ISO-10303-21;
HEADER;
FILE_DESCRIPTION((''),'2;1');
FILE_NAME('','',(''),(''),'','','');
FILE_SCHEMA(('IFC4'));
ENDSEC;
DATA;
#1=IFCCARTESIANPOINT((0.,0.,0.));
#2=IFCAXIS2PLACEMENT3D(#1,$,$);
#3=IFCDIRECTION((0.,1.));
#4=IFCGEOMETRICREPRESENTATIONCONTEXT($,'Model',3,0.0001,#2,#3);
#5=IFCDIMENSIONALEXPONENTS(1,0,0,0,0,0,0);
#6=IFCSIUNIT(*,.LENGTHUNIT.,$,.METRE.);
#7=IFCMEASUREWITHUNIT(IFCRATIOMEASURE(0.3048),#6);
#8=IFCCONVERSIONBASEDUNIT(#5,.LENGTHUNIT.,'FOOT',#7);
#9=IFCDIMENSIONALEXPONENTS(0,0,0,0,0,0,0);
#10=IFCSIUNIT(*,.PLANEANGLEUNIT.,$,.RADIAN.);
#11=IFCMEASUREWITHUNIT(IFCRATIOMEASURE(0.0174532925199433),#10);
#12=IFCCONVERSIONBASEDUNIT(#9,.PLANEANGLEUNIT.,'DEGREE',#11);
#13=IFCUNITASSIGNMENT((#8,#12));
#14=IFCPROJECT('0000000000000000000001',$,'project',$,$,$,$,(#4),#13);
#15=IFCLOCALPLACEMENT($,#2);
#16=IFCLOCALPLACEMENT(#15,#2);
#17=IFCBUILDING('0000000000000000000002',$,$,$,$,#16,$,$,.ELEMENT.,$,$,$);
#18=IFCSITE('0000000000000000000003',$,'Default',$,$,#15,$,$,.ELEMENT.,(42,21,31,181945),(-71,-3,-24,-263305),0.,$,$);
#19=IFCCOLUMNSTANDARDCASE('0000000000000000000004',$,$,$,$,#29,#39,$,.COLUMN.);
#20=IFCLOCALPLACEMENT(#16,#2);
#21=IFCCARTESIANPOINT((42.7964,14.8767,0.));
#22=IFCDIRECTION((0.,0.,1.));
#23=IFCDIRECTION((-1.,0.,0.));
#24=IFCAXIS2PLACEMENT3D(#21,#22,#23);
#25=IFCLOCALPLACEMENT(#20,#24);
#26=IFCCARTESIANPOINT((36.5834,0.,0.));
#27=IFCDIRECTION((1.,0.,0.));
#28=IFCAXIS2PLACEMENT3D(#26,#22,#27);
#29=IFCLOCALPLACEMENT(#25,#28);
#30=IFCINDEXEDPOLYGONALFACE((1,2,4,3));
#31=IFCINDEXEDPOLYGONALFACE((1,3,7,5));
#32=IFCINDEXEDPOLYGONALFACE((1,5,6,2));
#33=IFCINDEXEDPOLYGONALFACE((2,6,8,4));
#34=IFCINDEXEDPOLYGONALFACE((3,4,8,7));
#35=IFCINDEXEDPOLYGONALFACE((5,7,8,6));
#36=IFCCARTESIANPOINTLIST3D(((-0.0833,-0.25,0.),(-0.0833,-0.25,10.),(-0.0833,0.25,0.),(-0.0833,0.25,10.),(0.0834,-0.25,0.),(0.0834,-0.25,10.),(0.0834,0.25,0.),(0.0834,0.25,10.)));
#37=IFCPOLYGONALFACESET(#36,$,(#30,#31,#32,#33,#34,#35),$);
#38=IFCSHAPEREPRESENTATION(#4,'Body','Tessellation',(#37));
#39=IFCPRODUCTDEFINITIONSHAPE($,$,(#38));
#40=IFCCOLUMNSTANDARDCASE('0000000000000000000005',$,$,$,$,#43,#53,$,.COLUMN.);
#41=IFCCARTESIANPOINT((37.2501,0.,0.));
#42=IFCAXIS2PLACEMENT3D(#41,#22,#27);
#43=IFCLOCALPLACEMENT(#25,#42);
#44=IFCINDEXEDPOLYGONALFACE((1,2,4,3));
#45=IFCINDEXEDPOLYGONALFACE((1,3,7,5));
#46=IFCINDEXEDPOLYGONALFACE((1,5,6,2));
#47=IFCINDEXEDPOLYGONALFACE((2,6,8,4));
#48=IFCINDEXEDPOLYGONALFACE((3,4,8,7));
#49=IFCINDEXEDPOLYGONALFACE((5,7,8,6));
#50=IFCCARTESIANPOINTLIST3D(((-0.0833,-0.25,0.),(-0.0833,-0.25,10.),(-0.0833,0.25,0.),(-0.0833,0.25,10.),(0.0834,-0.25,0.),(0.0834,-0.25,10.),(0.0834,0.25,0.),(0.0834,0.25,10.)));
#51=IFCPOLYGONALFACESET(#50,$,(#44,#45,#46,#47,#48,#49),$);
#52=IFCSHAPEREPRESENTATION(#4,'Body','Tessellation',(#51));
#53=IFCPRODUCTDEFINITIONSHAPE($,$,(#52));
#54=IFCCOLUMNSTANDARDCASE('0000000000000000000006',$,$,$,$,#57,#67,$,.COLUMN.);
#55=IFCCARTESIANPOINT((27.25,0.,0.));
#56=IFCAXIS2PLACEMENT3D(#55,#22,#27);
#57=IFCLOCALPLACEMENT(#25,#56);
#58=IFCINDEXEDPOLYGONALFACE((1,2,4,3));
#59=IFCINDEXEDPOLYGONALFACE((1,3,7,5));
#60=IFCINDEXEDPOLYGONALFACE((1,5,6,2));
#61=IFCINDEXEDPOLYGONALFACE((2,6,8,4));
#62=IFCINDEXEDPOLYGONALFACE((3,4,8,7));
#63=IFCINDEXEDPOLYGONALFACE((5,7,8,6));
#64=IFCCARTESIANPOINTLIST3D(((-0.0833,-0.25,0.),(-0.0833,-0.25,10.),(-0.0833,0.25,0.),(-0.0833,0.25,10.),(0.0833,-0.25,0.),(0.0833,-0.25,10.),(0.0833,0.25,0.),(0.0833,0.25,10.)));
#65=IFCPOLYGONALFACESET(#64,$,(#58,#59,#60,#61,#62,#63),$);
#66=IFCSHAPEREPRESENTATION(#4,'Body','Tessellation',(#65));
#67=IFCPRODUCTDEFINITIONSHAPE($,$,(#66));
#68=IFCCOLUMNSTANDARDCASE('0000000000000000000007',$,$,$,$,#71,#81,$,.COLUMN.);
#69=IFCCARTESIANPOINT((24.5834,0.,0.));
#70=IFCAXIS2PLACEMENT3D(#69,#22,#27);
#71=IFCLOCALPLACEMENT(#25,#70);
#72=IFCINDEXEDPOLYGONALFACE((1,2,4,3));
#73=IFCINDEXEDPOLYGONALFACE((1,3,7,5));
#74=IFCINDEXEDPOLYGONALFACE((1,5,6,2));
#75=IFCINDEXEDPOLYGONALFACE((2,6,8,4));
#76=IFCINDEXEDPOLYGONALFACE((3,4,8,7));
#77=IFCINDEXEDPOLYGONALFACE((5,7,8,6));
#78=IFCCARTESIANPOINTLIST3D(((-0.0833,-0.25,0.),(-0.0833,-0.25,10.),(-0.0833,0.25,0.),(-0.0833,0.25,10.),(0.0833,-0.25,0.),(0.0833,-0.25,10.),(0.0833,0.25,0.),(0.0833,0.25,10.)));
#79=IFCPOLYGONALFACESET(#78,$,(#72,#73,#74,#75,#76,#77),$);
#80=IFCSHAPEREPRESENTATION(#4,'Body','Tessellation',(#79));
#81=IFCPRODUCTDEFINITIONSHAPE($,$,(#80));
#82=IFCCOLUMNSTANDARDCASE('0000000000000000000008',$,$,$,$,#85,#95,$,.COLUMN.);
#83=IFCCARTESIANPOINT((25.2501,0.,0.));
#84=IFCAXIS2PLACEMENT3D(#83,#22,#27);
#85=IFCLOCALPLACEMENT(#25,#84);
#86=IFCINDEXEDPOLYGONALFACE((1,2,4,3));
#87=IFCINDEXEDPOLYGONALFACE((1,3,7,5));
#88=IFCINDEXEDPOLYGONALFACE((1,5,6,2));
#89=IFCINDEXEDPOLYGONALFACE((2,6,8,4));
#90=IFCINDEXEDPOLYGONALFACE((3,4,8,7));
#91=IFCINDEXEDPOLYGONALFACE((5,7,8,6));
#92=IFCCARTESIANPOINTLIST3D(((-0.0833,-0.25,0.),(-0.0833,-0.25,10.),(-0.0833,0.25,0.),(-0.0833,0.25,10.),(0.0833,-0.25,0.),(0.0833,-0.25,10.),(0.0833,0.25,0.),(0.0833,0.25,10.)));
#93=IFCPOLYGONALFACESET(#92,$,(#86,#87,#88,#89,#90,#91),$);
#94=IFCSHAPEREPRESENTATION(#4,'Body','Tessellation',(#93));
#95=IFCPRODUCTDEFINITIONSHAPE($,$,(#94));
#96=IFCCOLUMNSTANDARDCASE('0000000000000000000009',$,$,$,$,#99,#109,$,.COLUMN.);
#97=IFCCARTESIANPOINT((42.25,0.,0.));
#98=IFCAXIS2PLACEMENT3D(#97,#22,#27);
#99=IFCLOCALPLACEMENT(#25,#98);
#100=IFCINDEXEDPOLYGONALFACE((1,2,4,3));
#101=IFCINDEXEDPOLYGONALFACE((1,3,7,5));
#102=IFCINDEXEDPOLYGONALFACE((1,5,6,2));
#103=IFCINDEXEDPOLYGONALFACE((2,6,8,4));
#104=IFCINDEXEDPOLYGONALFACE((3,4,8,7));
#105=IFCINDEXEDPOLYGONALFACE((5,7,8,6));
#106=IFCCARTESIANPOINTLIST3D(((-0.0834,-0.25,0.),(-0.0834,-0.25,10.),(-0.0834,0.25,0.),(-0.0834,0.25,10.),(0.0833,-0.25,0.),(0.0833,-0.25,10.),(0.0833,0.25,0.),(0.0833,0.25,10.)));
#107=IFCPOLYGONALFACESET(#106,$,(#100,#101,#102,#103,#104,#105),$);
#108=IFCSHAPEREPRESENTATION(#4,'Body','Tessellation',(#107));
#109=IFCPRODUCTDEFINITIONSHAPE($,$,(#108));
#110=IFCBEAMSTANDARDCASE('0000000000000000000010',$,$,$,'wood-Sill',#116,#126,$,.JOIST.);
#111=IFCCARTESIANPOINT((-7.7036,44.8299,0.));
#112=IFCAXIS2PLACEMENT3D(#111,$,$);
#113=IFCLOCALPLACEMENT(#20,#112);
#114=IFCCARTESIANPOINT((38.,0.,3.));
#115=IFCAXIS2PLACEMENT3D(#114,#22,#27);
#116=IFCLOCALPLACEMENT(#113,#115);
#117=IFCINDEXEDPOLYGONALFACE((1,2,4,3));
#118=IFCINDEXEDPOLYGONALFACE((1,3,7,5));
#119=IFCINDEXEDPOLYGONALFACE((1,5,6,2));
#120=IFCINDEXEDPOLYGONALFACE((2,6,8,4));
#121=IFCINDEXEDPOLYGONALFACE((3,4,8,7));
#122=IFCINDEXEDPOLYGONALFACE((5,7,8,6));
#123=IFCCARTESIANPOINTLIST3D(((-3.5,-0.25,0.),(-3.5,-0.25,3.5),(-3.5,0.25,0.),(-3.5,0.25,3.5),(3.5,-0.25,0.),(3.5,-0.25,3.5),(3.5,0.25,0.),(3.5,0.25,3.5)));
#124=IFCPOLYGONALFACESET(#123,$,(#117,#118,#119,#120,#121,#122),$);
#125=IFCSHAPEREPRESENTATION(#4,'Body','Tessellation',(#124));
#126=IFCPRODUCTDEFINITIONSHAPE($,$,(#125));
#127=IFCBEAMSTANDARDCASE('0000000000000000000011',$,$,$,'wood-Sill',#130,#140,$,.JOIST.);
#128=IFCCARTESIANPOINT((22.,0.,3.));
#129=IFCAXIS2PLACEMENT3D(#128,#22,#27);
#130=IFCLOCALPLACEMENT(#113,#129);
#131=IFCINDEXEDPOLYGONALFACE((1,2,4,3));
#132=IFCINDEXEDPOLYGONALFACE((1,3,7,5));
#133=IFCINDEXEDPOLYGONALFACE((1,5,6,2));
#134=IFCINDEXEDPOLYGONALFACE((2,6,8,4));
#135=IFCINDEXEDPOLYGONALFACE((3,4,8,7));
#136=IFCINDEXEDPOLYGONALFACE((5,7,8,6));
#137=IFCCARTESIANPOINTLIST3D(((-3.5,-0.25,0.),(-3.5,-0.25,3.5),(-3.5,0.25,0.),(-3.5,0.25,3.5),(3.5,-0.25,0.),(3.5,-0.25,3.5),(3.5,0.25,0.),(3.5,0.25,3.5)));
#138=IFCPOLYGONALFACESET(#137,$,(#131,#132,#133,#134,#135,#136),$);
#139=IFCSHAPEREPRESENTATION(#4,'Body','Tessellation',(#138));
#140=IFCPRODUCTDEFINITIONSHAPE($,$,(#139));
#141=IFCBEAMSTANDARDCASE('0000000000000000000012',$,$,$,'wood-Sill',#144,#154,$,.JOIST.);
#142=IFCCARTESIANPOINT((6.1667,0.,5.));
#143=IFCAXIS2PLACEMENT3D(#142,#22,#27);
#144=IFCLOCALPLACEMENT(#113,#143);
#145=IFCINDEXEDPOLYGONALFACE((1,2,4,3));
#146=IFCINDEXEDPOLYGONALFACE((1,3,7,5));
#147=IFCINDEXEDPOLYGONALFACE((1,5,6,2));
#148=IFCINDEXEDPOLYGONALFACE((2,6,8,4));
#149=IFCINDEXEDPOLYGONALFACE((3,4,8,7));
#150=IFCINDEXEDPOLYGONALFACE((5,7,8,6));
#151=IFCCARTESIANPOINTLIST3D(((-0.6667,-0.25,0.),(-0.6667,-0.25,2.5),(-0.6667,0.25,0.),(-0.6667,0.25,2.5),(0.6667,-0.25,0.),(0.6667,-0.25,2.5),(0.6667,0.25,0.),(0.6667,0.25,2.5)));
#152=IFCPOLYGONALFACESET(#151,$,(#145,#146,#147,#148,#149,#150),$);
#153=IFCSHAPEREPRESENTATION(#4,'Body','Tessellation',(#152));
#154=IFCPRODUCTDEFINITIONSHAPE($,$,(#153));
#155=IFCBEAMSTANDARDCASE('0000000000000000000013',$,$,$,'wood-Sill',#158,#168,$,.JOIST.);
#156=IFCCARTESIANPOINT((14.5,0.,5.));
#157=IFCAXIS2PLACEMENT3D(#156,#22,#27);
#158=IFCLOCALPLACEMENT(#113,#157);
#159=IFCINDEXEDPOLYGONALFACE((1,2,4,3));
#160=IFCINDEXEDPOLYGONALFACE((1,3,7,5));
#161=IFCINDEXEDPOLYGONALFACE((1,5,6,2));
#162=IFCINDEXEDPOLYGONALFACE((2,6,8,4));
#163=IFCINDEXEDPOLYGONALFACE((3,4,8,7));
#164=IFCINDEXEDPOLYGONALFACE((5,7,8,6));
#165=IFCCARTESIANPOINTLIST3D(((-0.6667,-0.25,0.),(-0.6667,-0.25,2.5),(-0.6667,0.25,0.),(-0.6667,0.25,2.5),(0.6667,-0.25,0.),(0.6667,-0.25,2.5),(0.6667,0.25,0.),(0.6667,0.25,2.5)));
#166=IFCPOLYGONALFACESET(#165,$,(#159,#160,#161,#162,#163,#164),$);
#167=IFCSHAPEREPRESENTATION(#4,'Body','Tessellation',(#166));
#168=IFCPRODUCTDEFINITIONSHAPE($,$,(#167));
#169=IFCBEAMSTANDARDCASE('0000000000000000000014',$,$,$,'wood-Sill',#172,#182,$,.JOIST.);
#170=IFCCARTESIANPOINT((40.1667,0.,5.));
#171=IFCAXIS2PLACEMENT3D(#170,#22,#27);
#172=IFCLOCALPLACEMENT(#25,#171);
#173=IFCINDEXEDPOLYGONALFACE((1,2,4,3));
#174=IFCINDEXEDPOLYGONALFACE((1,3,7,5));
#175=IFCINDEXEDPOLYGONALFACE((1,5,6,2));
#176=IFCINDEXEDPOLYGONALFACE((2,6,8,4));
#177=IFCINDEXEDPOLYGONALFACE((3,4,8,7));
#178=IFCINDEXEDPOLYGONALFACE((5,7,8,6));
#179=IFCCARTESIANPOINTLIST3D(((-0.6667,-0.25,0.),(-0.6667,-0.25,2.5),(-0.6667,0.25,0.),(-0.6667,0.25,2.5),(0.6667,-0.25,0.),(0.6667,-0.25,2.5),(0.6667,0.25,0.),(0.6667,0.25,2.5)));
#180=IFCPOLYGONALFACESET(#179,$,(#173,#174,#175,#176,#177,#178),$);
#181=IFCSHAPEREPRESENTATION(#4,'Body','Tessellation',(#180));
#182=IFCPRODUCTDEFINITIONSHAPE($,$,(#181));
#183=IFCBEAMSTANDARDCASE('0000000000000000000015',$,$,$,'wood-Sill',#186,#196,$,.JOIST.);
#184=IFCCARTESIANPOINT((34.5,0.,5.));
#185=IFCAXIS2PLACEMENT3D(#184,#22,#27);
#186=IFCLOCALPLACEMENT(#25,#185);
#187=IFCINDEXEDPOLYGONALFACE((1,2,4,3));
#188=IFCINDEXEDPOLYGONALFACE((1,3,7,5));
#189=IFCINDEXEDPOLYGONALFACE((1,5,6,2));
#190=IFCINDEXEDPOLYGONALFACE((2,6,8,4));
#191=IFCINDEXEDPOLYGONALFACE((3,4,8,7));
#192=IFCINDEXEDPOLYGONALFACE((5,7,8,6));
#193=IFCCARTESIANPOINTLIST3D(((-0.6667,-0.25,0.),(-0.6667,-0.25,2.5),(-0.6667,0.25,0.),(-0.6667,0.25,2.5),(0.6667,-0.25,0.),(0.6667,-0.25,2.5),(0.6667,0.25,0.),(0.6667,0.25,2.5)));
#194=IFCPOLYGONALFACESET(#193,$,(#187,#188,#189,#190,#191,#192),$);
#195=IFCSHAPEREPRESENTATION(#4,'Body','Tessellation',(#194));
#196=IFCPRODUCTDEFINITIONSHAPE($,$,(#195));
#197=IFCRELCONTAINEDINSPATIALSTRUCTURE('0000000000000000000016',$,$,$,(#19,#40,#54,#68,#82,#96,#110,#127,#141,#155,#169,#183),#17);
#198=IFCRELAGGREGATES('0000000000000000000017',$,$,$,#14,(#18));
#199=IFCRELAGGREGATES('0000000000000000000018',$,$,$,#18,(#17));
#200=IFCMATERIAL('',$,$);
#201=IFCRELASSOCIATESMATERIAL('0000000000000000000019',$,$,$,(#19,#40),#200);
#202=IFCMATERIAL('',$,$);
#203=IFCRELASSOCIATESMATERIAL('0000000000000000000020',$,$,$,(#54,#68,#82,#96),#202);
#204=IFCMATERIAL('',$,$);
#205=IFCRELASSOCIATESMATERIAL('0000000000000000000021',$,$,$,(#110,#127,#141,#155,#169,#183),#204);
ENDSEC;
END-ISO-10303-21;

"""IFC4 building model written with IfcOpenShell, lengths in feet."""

from ifc_helpers import new_model, entity, si_unit, converted_unit, direction, frame, origin, place, context, project, spatial, rectangle, extrude, material, element, save


model = new_model("IFC4")

# Units and contexts
model_context = context("Model", 3, precision=0.0001, world=origin(), true_north=direction((0.0, 1.0)))
ifc_project = project(units=[converted_unit("LENGTHUNIT", "FOOT", entity("IfcRatioMeasure", 0.3048), si_unit("LENGTHUNIT", "METRE"), dimensions=[1, 0, 0, 0, 0, 0, 0]), converted_unit("PLANEANGLEUNIT", "DEGREE", entity("IfcRatioMeasure", 0.0174532925199433), si_unit("PLANEANGLEUNIT", "RADIAN"), dimensions=[0, 0, 0, 0, 0, 0, 0])], contexts=[model_context])

# Site, building
site_placement = place(None, origin())
site = spatial("IfcSite", under=ifc_project, at=site_placement, Name="Default", CompositionType="ELEMENT", RefLatitude=(42, 21, 31, 181945), RefLongitude=(-71, -3, -24, -263305), RefElevation=0.0)
building_placement = place(site_placement, origin())
building = spatial("IfcBuilding", under=site, at=building_placement, CompositionType="ELEMENT")

# Columns
placement_1 = place(building_placement, origin())
placement_2 = place(placement_1, frame((-7.7036, 44.8299, 0.0)))
ifc_material_1 = material(Name="")
ifc_material_2 = material(Name="")
placement_3 = place(placement_1, frame((42.7964, 14.8767, 0.0), z_axis=(0.0, 0.0, 1.0), x_axis=(-1.0, 0.0, 0.0)))
for number, where, z_axis, x_axis in (
    (1, (36.5834, 0.0, 0.0), (0.0, 0.0, 1.0), (1.0, 0.0, 0.0)),
    (2, (37.2501, 0.0, 0.0), (0.0, 0.0, 1.0), (1.0, 0.0, 0.0)),
):
    element("IfcColumnStandardCase", number, at=place(placement_3, frame(where, z_axis=z_axis, x_axis=x_axis)), inside=building, material=ifc_material_1, PredefinedType="COLUMN", context=model_context, shape_type="SweptSolid", body=[
        extrude(rectangle(XDim=0.1667, YDim=0.5), origin(), (0.0, 0.0, 1.0), 10.0),
    ])
for number, where, z_axis, x_axis in (
    (3, (27.25, 0.0, 0.0), (0.0, 0.0, 1.0), (1.0, 0.0, 0.0)),
    (4, (24.5834, 0.0, 0.0), (0.0, 0.0, 1.0), (1.0, 0.0, 0.0)),
    (5, (25.2501, 0.0, 0.0), (0.0, 0.0, 1.0), (1.0, 0.0, 0.0)),
    (6, (42.25, 0.0, 0.0), (0.0, 0.0, 1.0), (1.0, 0.0, 0.0)),
):
    element("IfcColumnStandardCase", number, at=place(placement_3, frame(where, z_axis=z_axis, x_axis=x_axis)), inside=building, material=ifc_material_2, PredefinedType="COLUMN", context=model_context, shape_type="SweptSolid", body=[
        extrude(rectangle(XDim=0.1667, YDim=0.5), origin(), (0.0, 0.0, 1.0), 10.0),
    ])

# Beams
ifc_material_3 = material(Name="")
for number, where, z_axis, x_axis in (
    (7, (38.0, 0.0, 3.0), (0.0, 0.0, 1.0), (1.0, 0.0, 0.0)),
    (8, (22.0, 0.0, 3.0), (0.0, 0.0, 1.0), (1.0, 0.0, 0.0)),
):
    element("IfcBeamStandardCase", number, at=place(placement_2, frame(where, z_axis=z_axis, x_axis=x_axis)), inside=building, material=ifc_material_3, ObjectType="wood-Sill", PredefinedType="JOIST", context=model_context, shape_type="SweptSolid", body=[
        extrude(rectangle(XDim=7.0, YDim=0.5), origin(), (0.0, 0.0, 1.0), 3.5),
    ])
for number, where, z_axis, x_axis in (
    (9, (6.1667, 0.0, 5.0), (0.0, 0.0, 1.0), (1.0, 0.0, 0.0)),
    (10, (14.5, 0.0, 5.0), (0.0, 0.0, 1.0), (1.0, 0.0, 0.0)),
):
    element("IfcBeamStandardCase", number, at=place(placement_2, frame(where, z_axis=z_axis, x_axis=x_axis)), inside=building, material=ifc_material_3, ObjectType="wood-Sill", PredefinedType="JOIST", context=model_context, shape_type="SweptSolid", body=[
        extrude(rectangle(XDim=1.3333, YDim=0.5), origin(), (0.0, 0.0, 1.0), 2.5),
    ])
for number, where, z_axis, x_axis in (
    (11, (40.1667, 0.0, 5.0), (0.0, 0.0, 1.0), (1.0, 0.0, 0.0)),
    (12, (34.5, 0.0, 5.0), (0.0, 0.0, 1.0), (1.0, 0.0, 0.0)),
):
    element("IfcBeamStandardCase", number, at=place(placement_3, frame(where, z_axis=z_axis, x_axis=x_axis)), inside=building, material=ifc_material_3, ObjectType="wood-Sill", PredefinedType="JOIST", context=model_context, shape_type="SweptSolid", body=[
        extrude(rectangle(XDim=1.3333, YDim=0.5), origin(), (0.0, 0.0, 1.0), 2.5),
    ])

save(model, "model.ifc")
